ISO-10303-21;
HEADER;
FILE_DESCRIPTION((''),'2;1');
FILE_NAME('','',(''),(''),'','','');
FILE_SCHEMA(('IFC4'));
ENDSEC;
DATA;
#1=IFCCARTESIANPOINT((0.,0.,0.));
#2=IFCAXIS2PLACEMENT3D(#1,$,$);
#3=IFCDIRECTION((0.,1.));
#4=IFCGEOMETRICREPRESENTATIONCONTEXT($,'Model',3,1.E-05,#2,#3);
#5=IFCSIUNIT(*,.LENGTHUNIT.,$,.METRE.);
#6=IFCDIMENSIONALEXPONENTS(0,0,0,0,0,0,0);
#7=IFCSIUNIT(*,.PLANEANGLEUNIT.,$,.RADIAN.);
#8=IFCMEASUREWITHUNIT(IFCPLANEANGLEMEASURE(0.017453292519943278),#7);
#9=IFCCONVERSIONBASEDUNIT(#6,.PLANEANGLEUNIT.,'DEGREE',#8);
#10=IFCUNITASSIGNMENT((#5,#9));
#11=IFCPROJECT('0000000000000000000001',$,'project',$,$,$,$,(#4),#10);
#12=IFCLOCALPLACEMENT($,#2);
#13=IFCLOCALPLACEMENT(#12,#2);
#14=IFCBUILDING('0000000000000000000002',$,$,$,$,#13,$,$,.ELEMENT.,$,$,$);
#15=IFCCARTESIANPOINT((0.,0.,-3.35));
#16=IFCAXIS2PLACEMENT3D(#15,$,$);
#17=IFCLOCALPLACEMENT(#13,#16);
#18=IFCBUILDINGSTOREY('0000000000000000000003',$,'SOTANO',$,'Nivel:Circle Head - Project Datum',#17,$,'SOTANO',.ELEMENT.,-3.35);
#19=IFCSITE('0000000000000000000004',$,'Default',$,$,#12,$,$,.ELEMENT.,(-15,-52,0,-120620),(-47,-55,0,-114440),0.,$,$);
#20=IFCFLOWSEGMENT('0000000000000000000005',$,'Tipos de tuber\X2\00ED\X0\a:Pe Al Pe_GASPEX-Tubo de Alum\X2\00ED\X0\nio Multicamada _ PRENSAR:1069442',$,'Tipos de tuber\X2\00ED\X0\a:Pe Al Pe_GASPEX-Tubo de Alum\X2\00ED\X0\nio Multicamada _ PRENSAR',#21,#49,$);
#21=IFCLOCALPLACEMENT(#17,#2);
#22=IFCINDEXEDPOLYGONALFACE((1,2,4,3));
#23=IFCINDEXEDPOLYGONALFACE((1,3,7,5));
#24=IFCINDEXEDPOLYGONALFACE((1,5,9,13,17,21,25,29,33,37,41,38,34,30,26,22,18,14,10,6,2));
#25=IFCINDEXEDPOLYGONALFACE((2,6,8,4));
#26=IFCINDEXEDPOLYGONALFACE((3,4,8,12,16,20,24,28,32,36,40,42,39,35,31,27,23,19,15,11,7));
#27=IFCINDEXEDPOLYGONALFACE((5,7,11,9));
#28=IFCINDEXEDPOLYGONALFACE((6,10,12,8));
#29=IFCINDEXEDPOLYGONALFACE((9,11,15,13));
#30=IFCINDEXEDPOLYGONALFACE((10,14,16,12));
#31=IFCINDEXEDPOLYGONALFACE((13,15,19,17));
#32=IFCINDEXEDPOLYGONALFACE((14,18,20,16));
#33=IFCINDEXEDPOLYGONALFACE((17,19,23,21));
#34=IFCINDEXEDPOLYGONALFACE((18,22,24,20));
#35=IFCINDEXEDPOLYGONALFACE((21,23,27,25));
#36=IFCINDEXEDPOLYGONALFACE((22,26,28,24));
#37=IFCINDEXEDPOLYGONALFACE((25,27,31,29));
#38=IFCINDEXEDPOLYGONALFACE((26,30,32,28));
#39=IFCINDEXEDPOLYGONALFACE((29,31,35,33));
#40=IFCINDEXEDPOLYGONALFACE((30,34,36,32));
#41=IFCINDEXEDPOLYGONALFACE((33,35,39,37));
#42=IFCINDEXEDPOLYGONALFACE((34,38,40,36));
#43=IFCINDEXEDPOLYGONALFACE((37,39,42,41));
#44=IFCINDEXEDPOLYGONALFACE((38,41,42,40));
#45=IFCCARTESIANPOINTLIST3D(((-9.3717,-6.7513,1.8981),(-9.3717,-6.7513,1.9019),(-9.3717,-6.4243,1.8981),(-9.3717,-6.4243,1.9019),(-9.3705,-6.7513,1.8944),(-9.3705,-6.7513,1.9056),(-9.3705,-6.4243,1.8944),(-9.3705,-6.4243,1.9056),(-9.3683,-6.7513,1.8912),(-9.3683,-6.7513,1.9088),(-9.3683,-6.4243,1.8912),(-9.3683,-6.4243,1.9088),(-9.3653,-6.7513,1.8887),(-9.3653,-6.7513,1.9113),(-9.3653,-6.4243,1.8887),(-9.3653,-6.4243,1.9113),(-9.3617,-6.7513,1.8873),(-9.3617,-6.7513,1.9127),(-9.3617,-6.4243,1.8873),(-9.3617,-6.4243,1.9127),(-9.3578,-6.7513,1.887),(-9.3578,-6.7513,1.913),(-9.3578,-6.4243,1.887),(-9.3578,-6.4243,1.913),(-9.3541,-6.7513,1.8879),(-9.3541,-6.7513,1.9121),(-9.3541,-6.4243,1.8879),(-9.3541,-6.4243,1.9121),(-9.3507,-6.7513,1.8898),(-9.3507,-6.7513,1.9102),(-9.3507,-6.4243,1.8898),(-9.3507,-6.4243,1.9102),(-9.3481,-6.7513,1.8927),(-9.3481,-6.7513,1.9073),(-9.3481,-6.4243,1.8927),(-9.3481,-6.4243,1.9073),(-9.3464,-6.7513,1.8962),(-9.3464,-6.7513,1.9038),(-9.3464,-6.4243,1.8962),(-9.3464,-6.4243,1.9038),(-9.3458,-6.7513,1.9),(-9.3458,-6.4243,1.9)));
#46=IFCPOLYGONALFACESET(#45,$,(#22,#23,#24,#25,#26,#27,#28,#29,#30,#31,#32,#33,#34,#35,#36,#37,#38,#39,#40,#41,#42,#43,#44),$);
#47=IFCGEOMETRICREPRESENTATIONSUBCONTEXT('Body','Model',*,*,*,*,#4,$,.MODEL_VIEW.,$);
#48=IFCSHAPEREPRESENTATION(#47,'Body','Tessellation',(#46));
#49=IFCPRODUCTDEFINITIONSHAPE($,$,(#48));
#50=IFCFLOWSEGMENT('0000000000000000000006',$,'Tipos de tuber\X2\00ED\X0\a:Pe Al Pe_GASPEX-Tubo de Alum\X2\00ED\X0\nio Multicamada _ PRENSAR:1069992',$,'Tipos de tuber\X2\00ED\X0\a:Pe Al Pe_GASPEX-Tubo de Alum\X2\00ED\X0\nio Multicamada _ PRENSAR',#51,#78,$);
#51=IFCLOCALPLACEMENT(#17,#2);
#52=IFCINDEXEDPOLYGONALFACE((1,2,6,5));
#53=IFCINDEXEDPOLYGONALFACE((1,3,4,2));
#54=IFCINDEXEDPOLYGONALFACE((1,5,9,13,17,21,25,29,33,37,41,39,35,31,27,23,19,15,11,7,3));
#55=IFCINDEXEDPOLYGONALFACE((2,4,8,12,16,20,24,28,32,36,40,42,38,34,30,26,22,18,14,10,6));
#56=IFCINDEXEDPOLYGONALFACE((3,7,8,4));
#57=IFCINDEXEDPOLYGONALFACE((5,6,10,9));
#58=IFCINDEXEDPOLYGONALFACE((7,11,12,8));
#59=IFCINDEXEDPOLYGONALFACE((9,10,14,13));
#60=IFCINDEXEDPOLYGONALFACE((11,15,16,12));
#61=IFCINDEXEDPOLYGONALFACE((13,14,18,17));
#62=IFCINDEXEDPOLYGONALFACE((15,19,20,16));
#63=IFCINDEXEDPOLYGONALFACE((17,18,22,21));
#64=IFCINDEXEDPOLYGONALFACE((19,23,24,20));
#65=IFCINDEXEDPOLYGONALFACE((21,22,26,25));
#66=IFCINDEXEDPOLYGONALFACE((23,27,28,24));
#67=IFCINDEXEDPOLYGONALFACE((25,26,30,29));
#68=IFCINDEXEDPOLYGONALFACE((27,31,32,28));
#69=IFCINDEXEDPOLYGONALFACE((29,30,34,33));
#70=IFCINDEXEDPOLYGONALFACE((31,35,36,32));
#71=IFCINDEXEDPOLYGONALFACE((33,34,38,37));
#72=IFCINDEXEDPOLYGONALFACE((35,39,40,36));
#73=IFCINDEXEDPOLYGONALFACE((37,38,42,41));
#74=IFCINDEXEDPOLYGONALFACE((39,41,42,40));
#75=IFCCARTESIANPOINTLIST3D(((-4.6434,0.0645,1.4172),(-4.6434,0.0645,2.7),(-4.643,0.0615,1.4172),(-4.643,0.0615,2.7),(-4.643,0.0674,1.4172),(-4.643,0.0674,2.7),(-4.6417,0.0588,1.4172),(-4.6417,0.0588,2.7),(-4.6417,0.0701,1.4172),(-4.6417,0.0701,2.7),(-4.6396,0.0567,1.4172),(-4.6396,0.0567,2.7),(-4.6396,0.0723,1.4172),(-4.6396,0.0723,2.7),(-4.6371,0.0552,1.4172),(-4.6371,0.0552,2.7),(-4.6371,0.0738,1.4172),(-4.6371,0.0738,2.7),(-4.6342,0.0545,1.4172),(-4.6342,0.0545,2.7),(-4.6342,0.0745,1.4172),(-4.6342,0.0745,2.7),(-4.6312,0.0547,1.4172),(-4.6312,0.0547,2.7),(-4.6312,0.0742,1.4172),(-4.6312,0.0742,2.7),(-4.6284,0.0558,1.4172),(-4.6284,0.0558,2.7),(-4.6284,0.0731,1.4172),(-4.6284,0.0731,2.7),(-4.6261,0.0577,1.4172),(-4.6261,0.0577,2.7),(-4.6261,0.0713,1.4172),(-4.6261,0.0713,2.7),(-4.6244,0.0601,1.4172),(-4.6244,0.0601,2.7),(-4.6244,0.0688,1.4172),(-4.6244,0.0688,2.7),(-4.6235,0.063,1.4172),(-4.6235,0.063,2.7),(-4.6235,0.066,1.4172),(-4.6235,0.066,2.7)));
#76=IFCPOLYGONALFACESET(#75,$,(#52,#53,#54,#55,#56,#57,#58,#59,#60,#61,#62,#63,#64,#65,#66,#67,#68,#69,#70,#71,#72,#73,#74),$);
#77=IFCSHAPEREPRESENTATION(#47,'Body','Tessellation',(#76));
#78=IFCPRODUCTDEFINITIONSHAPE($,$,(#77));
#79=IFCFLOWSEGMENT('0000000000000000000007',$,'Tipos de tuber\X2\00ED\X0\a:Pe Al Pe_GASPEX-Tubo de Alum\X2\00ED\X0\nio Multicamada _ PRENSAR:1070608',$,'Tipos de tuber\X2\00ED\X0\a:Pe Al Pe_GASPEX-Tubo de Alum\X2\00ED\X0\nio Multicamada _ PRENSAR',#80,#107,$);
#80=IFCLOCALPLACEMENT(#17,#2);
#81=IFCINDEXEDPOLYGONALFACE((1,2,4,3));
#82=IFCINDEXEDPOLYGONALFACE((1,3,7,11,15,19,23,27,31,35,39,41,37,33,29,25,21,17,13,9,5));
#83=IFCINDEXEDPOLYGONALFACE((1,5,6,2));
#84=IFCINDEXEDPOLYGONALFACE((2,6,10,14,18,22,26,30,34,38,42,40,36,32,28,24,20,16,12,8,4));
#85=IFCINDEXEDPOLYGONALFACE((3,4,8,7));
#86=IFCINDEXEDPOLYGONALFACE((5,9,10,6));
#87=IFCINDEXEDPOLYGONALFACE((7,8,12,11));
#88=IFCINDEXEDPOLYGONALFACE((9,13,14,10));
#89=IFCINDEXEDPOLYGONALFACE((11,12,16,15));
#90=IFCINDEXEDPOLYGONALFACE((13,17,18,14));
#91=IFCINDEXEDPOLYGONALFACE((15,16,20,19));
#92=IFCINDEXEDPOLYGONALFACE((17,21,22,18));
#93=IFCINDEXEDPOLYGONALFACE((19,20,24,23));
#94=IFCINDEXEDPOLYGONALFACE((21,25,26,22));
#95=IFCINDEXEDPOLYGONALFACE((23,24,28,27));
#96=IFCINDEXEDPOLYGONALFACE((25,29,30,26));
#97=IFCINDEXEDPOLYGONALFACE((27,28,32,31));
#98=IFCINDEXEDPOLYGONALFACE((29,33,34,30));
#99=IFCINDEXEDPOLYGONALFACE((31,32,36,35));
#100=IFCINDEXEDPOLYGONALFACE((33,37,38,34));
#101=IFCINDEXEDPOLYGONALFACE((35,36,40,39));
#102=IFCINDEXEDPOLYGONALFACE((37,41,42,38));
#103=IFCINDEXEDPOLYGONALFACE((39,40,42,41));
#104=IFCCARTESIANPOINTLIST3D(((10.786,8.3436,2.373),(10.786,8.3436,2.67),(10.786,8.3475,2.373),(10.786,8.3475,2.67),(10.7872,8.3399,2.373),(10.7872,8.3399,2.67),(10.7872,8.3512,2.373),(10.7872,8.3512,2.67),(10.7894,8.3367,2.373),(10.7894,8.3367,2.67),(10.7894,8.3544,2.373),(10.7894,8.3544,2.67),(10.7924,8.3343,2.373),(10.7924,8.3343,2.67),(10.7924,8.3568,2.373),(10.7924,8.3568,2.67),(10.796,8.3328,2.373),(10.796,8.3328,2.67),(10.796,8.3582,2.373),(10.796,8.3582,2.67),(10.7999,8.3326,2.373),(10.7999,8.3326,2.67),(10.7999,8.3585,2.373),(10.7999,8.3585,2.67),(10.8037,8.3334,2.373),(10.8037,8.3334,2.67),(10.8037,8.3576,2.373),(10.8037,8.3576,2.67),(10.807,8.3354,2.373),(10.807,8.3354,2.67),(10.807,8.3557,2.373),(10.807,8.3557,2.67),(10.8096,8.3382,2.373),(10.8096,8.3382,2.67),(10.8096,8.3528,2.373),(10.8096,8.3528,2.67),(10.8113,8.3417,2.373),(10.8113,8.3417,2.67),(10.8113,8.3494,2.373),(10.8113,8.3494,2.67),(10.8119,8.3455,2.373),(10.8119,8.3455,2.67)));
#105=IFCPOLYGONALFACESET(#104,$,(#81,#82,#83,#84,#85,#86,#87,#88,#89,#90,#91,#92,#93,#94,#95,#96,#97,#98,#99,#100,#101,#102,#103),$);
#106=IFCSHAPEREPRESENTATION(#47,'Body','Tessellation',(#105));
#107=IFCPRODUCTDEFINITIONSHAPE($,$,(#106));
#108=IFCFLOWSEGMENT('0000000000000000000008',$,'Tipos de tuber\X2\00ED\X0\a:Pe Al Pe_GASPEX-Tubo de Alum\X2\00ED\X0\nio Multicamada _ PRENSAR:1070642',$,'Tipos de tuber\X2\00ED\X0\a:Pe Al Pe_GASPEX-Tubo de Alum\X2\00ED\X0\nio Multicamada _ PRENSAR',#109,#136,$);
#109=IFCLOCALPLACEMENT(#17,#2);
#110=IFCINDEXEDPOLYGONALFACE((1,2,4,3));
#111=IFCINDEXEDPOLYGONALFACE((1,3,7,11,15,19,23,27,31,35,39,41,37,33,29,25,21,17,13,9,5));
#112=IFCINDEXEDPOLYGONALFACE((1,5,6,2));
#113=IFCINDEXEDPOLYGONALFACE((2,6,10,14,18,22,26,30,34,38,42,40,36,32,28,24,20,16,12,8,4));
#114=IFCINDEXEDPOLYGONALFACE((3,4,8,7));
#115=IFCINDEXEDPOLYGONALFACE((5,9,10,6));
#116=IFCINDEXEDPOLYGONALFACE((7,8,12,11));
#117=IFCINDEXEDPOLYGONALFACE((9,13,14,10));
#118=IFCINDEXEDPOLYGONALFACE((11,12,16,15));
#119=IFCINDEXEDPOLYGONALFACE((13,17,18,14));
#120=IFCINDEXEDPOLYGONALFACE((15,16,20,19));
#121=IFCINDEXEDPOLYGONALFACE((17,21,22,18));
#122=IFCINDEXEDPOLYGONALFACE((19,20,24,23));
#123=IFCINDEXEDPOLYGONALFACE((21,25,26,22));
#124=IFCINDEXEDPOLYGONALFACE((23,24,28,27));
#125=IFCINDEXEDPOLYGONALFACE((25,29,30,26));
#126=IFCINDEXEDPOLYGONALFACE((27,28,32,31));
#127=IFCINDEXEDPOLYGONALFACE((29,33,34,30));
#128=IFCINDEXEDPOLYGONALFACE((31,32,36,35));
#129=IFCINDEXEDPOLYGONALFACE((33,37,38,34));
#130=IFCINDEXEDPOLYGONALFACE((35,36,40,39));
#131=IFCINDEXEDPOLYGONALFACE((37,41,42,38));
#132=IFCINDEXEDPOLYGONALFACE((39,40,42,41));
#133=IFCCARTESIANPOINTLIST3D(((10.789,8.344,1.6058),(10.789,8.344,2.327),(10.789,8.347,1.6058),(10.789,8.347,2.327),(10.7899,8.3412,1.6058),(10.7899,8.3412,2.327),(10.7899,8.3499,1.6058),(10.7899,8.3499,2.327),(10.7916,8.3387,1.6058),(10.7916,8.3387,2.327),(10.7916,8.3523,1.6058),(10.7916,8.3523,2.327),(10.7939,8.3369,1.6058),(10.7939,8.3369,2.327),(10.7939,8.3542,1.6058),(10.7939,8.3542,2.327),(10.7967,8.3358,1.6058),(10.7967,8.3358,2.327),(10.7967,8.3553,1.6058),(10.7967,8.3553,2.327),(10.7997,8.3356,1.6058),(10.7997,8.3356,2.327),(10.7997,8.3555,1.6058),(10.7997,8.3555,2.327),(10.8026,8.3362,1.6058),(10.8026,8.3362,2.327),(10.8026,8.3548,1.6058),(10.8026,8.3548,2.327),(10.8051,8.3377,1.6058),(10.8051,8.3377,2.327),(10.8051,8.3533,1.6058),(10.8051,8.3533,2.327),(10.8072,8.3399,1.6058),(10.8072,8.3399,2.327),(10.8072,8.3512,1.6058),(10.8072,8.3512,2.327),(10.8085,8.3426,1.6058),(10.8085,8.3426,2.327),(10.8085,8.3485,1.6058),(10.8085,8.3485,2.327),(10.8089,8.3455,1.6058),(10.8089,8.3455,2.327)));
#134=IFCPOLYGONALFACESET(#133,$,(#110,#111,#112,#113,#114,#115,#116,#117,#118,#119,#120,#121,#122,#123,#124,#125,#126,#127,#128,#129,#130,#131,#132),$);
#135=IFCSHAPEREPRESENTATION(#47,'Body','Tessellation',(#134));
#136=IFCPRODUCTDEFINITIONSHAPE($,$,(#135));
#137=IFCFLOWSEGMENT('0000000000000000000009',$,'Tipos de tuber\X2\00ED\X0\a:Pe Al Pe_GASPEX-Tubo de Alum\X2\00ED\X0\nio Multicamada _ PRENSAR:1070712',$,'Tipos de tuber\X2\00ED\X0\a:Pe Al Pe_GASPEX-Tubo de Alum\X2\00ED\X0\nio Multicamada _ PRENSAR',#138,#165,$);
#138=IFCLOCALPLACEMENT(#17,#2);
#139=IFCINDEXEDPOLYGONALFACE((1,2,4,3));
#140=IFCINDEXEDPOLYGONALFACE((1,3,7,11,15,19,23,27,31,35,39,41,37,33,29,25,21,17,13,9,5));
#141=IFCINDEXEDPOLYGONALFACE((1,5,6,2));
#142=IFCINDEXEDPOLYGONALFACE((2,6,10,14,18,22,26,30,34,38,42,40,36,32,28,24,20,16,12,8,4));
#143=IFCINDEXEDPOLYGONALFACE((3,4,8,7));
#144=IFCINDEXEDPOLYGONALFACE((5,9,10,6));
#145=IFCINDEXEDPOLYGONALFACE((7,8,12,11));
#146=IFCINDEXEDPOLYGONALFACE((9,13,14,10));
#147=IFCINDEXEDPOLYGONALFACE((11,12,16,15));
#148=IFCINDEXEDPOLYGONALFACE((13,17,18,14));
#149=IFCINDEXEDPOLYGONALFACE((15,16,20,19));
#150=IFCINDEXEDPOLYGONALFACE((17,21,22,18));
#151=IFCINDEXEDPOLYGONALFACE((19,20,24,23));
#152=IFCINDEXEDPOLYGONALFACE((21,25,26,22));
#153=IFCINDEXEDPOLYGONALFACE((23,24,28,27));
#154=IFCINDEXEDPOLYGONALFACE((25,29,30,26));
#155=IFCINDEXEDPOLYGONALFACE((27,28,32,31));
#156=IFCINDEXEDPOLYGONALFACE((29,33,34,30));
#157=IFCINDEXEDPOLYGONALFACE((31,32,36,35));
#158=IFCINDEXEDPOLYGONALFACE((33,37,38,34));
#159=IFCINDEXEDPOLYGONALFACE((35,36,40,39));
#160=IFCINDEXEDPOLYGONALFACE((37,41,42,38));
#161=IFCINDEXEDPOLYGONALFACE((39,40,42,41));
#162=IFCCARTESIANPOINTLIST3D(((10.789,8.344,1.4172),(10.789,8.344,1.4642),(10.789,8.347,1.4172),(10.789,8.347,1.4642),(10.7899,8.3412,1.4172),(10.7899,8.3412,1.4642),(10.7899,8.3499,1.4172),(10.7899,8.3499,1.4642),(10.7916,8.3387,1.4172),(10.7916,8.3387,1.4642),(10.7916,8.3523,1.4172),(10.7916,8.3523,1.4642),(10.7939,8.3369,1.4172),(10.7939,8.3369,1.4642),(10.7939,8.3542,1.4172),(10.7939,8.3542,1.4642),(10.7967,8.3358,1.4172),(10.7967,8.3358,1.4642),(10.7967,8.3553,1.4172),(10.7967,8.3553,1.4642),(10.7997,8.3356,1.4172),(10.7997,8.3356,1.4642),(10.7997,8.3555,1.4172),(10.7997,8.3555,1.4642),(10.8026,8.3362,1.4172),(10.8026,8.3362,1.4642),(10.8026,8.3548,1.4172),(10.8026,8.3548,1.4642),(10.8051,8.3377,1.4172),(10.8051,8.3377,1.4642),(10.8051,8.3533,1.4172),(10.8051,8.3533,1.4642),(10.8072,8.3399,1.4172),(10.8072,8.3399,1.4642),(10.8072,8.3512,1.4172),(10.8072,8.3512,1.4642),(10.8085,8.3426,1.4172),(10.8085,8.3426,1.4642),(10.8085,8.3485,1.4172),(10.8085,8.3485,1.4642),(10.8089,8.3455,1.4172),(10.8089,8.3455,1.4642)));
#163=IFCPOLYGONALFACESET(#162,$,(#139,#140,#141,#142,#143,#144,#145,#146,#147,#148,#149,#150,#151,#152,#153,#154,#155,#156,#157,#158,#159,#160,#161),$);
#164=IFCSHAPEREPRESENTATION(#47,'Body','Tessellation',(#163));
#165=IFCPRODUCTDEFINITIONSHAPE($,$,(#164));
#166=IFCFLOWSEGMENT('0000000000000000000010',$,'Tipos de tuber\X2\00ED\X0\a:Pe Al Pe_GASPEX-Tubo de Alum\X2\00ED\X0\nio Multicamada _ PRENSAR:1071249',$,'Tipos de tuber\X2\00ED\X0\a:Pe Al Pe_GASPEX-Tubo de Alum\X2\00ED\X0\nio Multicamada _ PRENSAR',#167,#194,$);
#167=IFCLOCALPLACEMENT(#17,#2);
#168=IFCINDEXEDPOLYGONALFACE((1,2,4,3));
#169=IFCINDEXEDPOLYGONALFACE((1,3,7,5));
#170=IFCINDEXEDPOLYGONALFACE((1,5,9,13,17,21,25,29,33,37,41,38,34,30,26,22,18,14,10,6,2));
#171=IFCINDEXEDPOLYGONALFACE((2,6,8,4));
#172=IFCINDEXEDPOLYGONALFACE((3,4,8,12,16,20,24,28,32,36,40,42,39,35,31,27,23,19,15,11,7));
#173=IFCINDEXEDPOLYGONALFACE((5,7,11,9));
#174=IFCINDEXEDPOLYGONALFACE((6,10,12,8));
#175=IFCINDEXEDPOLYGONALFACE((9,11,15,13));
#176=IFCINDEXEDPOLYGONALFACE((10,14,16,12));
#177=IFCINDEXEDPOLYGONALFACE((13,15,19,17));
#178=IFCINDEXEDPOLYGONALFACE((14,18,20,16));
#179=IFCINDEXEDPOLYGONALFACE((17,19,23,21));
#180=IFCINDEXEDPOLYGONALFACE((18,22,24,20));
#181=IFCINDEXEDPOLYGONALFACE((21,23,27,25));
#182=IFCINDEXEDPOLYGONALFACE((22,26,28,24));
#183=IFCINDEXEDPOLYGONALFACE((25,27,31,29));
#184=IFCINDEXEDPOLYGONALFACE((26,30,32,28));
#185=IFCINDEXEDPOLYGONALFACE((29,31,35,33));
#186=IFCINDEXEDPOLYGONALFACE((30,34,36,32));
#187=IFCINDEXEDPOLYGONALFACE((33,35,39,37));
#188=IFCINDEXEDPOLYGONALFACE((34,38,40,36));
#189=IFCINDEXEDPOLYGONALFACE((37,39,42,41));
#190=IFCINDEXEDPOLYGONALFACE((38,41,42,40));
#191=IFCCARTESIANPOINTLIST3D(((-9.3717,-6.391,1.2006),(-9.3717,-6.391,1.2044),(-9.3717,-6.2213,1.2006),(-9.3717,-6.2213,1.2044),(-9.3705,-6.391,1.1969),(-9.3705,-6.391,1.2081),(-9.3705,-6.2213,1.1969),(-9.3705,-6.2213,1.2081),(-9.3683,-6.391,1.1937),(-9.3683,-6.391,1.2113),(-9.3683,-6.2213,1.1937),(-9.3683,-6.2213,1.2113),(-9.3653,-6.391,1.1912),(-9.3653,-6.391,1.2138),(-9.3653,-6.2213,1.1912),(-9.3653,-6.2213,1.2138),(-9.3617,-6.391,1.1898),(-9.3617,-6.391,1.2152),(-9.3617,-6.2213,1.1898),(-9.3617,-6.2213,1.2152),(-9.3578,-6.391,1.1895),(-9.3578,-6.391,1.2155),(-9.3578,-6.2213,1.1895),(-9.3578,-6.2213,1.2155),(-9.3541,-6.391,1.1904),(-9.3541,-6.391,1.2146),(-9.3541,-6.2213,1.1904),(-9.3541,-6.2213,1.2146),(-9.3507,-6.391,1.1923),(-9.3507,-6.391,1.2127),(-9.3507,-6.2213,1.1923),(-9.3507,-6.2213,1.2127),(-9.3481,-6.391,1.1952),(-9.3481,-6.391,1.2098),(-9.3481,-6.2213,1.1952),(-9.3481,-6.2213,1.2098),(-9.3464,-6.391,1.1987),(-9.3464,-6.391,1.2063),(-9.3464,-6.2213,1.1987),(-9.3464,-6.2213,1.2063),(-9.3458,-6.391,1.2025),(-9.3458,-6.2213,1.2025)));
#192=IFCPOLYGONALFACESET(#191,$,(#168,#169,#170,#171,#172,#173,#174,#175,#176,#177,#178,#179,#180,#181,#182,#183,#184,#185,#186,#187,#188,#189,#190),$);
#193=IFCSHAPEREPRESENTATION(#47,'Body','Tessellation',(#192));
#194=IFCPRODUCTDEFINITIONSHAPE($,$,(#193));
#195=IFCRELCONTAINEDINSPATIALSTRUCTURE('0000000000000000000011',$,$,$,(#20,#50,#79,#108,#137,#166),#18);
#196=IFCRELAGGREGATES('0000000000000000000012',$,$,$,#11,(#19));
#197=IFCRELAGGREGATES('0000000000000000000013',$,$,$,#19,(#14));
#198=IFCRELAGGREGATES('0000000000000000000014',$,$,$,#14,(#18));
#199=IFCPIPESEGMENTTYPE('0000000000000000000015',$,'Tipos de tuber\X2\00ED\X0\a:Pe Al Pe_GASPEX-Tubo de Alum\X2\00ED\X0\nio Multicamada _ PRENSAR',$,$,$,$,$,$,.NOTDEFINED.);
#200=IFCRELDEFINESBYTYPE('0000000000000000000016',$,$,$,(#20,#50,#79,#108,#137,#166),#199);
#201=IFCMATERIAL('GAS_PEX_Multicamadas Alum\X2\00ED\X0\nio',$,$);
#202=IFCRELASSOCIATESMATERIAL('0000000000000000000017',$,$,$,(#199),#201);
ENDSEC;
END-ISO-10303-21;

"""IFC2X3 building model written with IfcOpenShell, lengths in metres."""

from ifc_helpers import new_model, entity, si_unit, converted_unit, direction, frame, frame_2d, origin, origin_2d_with_axis, place, context, subcontext, project, spatial, circle, extrude, material, type_object, element, save


model = new_model("IFC2X3")

# Units and contexts
model_context = context("Model", 3, precision=1e-05, world=origin(), true_north=direction((0.0, 1.0)))
body_context = subcontext(model_context, "Body", "Model", "MODEL_VIEW")
ifc_project = project(units=[si_unit("LENGTHUNIT", "METRE"), converted_unit("PLANEANGLEUNIT", "DEGREE", entity("IfcPlaneAngleMeasure", 0.017453292519943278), si_unit("PLANEANGLEUNIT", "RADIAN"), dimensions=[0, 0, 0, 0, 0, 0, 0])], contexts=[model_context])

# Site, building, storey
site_placement = place(None, origin())
site = spatial("IfcSite", under=ifc_project, at=site_placement, Name="Default", CompositionType="ELEMENT", RefLatitude=(-15, -52, 0, -120620), RefLongitude=(-47, -55, 0, -114440), RefElevation=0.0)
building_placement = place(site_placement, origin())
building = spatial("IfcBuilding", under=site, at=building_placement, CompositionType="ELEMENT")
storey_placement = place(building_placement, frame((0.0, 0.0, -3.35)))
storey = spatial("IfcBuildingStorey", under=building, at=storey_placement, Name="SOTANO", ObjectType="Nivel:Circle Head - Project Datum", LongName="SOTANO", CompositionType="ELEMENT", Elevation=-3.35)

# Flow segments
ifc_material = material(Name="GAS_PEX_Multicamadas Alumínio")
pipe_segment_type_1 = type_object("IfcPipeSegmentType", Name="Tipos de tubería:Pe Al Pe_GASPEX-Tubo de Alumínio Multicamada _ PRENSAR", PredefinedType="NOTDEFINED", material=ifc_material)
flow_segment_1_placement = place(storey_placement, origin())
element("IfcFlowSegment", 1, at=flow_segment_1_placement, inside=storey, type_object=pipe_segment_type_1, Name="Tipos de tubería:Pe Al Pe_GASPEX-Tubo de Alumínio Multicamada _ PRENSAR:1069442", ObjectType="Tipos de tubería:Pe Al Pe_GASPEX-Tubo de Alumínio Multicamada _ PRENSAR", context=body_context, shape_type="SweptSolid", body=[
    extrude(circle(Radius=0.013, at=frame_2d((0.0, 0.0), x_axis=(1.0, 0.0))), frame((-9.3588, -6.7513, 1.9), z_axis=(0.0, 1.0, 0.0), x_axis=(1.0, 0.0, 0.0)), (0.0, 0.0, 1.0), 0.327),
])
flow_segment_2_placement = place(storey_placement, origin())
element("IfcFlowSegment", 2, at=flow_segment_2_placement, inside=storey, type_object=pipe_segment_type_1, Name="Tipos de tubería:Pe Al Pe_GASPEX-Tubo de Alumínio Multicamada _ PRENSAR:1069992", ObjectType="Tipos de tubería:Pe Al Pe_GASPEX-Tubo de Alumínio Multicamada _ PRENSAR", context=body_context, shape_type="SweptSolid", body=[
    extrude(circle(Radius=0.01, at=frame_2d((0.0, 0.0), x_axis=(1.0, 0.0))), frame((-4.6334, 0.0645, 1.4171), z_axis=(0.0, 0.0, 1.0), x_axis=(-1.0, 0.0, 0.0)), (0.0, 0.0, 1.0), 1.2828),
])
flow_segment_3_placement = place(storey_placement, origin())
element("IfcFlowSegment", 3, at=flow_segment_3_placement, inside=storey, type_object=pipe_segment_type_1, Name="Tipos de tubería:Pe Al Pe_GASPEX-Tubo de Alumínio Multicamada _ PRENSAR:1070608", ObjectType="Tipos de tubería:Pe Al Pe_GASPEX-Tubo de Alumínio Multicamada _ PRENSAR", context=body_context, shape_type="SweptSolid", body=[
    extrude(circle(Radius=0.013, at=origin_2d_with_axis()), frame((10.7989, 8.3455, 2.373)), (0.0, 0.0, 1.0), 0.297),
])
flow_segment_4_placement = place(storey_placement, origin())
element("IfcFlowSegment", 4, at=flow_segment_4_placement, inside=storey, type_object=pipe_segment_type_1, Name="Tipos de tubería:Pe Al Pe_GASPEX-Tubo de Alumínio Multicamada _ PRENSAR:1070642", ObjectType="Tipos de tubería:Pe Al Pe_GASPEX-Tubo de Alumínio Multicamada _ PRENSAR", context=body_context, shape_type="SweptSolid", body=[
    extrude(circle(Radius=0.01, at=origin_2d_with_axis()), frame((10.7989, 8.3455, 1.6058)), (0.0, 0.0, 1.0), 0.7211),
])
flow_segment_5_placement = place(storey_placement, origin())
element("IfcFlowSegment", 5, at=flow_segment_5_placement, inside=storey, type_object=pipe_segment_type_1, Name="Tipos de tubería:Pe Al Pe_GASPEX-Tubo de Alumínio Multicamada _ PRENSAR:1070712", ObjectType="Tipos de tubería:Pe Al Pe_GASPEX-Tubo de Alumínio Multicamada _ PRENSAR", context=body_context, shape_type="SweptSolid", body=[
    extrude(circle(Radius=0.01, at=origin_2d_with_axis()), frame((10.7989, 8.3455, 1.4171)), (0.0, 0.0, 1.0), 0.047),
])
flow_segment_6_placement = place(storey_placement, origin())
element("IfcFlowSegment", 6, at=flow_segment_6_placement, inside=storey, type_object=pipe_segment_type_1, Name="Tipos de tubería:Pe Al Pe_GASPEX-Tubo de Alumínio Multicamada _ PRENSAR:1071249", ObjectType="Tipos de tubería:Pe Al Pe_GASPEX-Tubo de Alumínio Multicamada _ PRENSAR", context=body_context, shape_type="SweptSolid", body=[
    extrude(circle(Radius=0.013, at=frame_2d((0.0, 0.0), x_axis=(1.0, 0.0))), frame((-9.3588, -6.391, 1.2025), z_axis=(0.0, 1.0, 0.0), x_axis=(1.0, 0.0, 0.0)), (0.0, 0.0, 1.0), 0.1696),
])

save(model, "model.ifc")
